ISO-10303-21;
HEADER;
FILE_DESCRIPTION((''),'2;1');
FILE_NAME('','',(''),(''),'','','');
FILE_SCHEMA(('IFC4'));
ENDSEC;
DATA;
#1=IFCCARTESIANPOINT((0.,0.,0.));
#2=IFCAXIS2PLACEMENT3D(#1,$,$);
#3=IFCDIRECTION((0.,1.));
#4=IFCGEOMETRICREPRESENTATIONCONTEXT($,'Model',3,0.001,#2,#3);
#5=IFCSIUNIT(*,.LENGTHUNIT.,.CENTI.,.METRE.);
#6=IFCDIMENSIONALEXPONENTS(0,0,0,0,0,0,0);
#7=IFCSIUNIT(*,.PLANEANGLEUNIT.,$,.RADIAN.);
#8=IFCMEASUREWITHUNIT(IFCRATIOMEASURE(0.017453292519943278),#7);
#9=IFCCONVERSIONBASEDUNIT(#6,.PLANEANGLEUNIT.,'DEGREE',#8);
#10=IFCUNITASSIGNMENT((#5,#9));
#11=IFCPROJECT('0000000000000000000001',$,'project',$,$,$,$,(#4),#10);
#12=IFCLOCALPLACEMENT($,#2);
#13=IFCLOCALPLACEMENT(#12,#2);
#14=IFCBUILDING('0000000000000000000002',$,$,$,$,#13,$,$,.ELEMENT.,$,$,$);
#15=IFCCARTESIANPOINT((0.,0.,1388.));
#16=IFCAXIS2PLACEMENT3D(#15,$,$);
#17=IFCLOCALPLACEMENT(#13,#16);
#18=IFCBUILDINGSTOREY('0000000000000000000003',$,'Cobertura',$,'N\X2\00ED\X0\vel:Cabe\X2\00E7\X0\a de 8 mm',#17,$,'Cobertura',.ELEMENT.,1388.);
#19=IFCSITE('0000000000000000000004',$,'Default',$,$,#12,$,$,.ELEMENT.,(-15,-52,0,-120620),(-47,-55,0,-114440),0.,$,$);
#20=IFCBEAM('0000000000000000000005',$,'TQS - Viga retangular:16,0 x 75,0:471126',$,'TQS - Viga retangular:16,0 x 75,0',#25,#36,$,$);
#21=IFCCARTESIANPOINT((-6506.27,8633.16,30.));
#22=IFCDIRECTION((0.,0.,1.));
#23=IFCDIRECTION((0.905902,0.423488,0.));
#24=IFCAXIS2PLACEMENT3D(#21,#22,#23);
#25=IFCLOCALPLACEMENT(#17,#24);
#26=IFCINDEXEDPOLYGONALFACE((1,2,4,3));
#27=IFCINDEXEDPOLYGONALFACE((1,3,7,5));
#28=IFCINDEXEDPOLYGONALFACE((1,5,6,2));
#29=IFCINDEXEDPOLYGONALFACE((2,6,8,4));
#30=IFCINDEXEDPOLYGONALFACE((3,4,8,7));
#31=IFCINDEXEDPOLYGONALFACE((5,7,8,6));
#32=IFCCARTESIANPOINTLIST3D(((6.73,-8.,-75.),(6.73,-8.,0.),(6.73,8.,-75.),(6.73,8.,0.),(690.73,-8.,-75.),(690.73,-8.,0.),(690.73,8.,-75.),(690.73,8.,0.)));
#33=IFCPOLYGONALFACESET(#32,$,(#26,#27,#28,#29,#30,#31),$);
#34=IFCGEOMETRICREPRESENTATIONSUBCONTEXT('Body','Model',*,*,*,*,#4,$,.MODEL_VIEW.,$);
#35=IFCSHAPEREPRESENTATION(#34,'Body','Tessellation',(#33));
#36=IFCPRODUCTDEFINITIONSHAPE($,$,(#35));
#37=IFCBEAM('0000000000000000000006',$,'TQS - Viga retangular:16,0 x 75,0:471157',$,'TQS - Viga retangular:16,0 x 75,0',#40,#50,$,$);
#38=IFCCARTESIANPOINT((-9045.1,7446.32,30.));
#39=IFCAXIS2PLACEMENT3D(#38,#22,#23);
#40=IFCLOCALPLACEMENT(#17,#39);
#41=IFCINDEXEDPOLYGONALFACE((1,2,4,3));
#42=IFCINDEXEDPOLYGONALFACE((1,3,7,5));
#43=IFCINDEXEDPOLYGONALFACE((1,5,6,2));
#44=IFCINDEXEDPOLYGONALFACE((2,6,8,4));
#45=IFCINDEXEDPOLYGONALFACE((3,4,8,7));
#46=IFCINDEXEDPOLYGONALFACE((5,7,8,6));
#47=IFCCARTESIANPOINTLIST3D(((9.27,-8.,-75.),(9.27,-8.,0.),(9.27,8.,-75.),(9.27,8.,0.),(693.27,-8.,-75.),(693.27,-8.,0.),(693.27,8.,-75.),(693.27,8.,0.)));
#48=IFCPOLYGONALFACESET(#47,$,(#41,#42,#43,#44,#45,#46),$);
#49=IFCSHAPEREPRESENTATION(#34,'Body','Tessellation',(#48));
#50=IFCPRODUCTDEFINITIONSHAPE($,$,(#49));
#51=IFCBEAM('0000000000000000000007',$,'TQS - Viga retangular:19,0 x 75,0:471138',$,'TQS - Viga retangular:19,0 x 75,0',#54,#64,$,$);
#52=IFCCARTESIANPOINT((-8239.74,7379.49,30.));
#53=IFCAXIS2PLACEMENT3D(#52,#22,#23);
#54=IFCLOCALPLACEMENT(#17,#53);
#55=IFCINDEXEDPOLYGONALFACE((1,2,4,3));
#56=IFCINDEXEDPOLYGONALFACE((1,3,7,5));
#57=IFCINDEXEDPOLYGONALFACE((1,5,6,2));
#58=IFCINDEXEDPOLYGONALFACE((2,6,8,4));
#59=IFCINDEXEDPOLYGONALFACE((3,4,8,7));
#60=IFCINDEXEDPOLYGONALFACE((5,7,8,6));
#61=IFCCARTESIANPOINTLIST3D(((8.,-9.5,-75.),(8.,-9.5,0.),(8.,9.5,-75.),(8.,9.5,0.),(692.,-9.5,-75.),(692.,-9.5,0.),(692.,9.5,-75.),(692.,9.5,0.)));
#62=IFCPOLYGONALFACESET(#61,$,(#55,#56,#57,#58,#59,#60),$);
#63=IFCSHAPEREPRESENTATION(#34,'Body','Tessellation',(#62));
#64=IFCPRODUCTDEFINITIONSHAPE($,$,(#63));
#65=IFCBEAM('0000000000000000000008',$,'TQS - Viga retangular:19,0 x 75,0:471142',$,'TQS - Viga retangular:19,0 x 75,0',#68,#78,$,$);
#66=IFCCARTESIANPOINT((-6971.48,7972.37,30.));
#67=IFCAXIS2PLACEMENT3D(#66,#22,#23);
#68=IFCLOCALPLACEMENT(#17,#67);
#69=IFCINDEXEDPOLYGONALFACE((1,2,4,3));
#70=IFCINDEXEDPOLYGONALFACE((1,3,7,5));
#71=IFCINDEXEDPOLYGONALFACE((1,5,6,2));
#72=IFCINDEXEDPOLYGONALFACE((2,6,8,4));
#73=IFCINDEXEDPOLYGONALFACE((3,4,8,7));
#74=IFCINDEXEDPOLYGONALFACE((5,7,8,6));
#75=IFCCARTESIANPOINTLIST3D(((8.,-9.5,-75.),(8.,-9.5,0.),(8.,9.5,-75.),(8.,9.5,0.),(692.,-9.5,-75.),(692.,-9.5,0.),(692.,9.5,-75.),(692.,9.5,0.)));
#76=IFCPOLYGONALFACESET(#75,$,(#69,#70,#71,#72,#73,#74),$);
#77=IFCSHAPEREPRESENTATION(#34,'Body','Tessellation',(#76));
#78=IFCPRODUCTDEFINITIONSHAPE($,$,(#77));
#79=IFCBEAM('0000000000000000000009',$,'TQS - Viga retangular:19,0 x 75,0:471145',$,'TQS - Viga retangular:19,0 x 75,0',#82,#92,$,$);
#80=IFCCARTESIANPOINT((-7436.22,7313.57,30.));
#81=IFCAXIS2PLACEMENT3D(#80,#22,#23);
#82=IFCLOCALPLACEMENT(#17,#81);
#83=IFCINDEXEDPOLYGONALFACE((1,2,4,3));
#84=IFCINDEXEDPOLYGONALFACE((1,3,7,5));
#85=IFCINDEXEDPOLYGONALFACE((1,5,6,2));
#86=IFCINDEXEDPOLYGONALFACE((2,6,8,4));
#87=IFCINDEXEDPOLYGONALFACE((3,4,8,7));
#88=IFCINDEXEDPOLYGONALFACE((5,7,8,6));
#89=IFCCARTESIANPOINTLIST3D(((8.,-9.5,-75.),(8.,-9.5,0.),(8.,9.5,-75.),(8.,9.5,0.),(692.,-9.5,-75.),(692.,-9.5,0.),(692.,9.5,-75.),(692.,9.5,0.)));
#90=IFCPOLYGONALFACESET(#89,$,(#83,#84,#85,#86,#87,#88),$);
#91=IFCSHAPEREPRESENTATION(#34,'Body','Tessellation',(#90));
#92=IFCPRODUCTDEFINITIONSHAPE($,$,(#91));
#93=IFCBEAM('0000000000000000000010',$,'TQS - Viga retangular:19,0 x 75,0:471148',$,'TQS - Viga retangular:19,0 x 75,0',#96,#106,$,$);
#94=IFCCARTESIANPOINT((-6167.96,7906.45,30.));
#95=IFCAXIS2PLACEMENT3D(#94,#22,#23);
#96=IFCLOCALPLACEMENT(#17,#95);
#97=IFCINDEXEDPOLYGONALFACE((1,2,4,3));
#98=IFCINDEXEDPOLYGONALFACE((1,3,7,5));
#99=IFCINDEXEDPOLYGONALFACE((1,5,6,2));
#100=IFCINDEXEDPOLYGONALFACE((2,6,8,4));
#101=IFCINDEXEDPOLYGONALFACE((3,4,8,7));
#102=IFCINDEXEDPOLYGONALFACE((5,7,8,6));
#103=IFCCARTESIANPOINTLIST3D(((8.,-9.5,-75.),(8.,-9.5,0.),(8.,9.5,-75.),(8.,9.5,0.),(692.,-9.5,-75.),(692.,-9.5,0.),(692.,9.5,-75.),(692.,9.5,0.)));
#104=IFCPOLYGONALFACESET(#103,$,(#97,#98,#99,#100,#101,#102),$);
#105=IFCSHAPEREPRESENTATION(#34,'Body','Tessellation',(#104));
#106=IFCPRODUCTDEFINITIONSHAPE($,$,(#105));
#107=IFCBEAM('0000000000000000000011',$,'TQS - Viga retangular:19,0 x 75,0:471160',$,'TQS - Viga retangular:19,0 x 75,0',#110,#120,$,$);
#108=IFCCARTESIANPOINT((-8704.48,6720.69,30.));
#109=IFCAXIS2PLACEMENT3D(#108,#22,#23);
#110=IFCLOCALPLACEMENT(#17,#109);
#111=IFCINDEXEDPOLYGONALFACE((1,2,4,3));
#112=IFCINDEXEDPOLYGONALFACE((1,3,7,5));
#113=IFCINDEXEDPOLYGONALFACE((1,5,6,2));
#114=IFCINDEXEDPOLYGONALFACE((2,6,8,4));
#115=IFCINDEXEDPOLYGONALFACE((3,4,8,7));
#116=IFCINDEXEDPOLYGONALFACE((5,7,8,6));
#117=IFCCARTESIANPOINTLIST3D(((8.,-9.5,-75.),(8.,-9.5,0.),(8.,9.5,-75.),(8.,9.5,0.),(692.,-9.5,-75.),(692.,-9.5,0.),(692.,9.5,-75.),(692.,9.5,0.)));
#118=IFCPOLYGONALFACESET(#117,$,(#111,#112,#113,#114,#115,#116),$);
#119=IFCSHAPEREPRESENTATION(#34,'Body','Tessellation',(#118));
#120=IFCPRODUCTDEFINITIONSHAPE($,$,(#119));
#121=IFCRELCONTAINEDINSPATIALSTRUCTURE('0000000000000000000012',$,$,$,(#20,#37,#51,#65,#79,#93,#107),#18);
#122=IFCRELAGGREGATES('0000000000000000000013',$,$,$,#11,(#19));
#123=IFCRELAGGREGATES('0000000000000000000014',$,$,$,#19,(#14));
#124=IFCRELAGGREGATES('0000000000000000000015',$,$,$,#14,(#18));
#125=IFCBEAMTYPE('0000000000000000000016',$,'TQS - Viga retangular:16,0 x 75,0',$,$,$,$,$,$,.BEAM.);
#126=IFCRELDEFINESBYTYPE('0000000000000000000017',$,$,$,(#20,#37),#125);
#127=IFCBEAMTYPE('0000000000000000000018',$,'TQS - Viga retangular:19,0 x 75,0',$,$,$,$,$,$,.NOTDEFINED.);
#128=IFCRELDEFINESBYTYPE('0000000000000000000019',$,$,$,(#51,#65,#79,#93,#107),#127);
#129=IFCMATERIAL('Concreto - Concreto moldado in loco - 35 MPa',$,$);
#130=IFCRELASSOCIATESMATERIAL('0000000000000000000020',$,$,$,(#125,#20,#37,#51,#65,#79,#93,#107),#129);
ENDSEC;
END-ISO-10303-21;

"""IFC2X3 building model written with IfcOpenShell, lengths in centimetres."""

from ifc_helpers import new_model, entity, si_unit, converted_unit, direction, frame, frame_2d, origin, place, context, subcontext, project, spatial, rectangle, extrude, material, type_object, element, save


model = new_model("IFC2X3")

# Units and contexts
model_context = context("Model", 3, precision=0.001, world=origin(), true_north=direction((0.0, 1.0)))
body_context = subcontext(model_context, "Body", "Model", "MODEL_VIEW")
ifc_project = project(units=[si_unit("LENGTHUNIT", "METRE", prefix="CENTI"), converted_unit("PLANEANGLEUNIT", "DEGREE", entity("IfcRatioMeasure", 0.017453292519943278), si_unit("PLANEANGLEUNIT", "RADIAN"), dimensions=[0, 0, 0, 0, 0, 0, 0])], contexts=[model_context])

# Site, building, storey
site_placement = place(None, origin())
site = spatial("IfcSite", under=ifc_project, at=site_placement, Name="Default", CompositionType="ELEMENT", RefLatitude=(-15, -52, 0, -120620), RefLongitude=(-47, -55, 0, -114440), RefElevation=0.0)
building_placement = place(site_placement, origin())
building = spatial("IfcBuilding", under=site, at=building_placement, CompositionType="ELEMENT")
storey_placement = place(building_placement, frame((0.0, 0.0, 1388.0)))
storey = spatial("IfcBuildingStorey", under=building, at=storey_placement, Name="Cobertura", ObjectType="Nível:Cabeça de 8 mm", LongName="Cobertura", CompositionType="ELEMENT", Elevation=1388.0)

# Beams
ifc_material = material(Name="Concreto - Concreto moldado in loco - 35 MPa")
beam_type_1 = type_object("IfcBeamType", Name="TQS - Viga retangular:16,0 x 75,0", PredefinedType="BEAM", material=ifc_material)
beam_1_placement = place(storey_placement, frame((-6506.27, 8633.16, 30.0), z_axis=(0.0, 0.0, 1.0), x_axis=(0.905902, 0.423488, 0.0)))
element("IfcBeam", 1, at=beam_1_placement, inside=storey, type_object=beam_type_1, material=ifc_material, Name="TQS - Viga retangular:16,0 x 75,0:471126", ObjectType="TQS - Viga retangular:16,0 x 75,0", context=body_context, shape_type="SweptSolid", body=[
    extrude(rectangle(XDim=75.0, YDim=16.0, at=frame_2d((0.0, 0.0), x_axis=(1.0, 0.0))), frame((6.73, 0.0, -37.5), z_axis=(1.0, 0.0, 0.0), x_axis=(0.0, 0.0, -1.0)), (0.0, 0.0, 1.0), 684.0),
])
beam_2_placement = place(storey_placement, frame((-9045.1, 7446.32, 30.0), z_axis=(0.0, 0.0, 1.0), x_axis=(0.905902, 0.423488, 0.0)))
element("IfcBeam", 2, at=beam_2_placement, inside=storey, type_object=beam_type_1, material=ifc_material, Name="TQS - Viga retangular:16,0 x 75,0:471157", ObjectType="TQS - Viga retangular:16,0 x 75,0", context=body_context, shape_type="SweptSolid", body=[
    extrude(rectangle(XDim=75.0, YDim=16.0, at=frame_2d((0.0, 0.0), x_axis=(1.0, 0.0))), frame((9.27, 0.0, -37.5), z_axis=(1.0, 0.0, 0.0), x_axis=(0.0, 0.0, -1.0)), (0.0, 0.0, 1.0), 684.0),
])
beam_type_2 = type_object("IfcBeamType", Name="TQS - Viga retangular:19,0 x 75,0", PredefinedType="NOTDEFINED")
beam_3_placement = place(storey_placement, frame((-8239.74, 7379.49, 30.0), z_axis=(0.0, 0.0, 1.0), x_axis=(0.905902, 0.423488, 0.0)))
element("IfcBeam", 3, at=beam_3_placement, inside=storey, type_object=beam_type_2, material=ifc_material, Name="TQS - Viga retangular:19,0 x 75,0:471138", ObjectType="TQS - Viga retangular:19,0 x 75,0", context=body_context, shape_type="SweptSolid", body=[
    extrude(rectangle(XDim=75.0, YDim=19.0, at=frame_2d((0.0, 0.0), x_axis=(1.0, 0.0))), frame((8.0, 0.0, -37.5), z_axis=(1.0, 0.0, 0.0), x_axis=(0.0, 0.0, -1.0)), (0.0, 0.0, 1.0), 684.0),
])
beam_4_placement = place(storey_placement, frame((-6971.48, 7972.37, 30.0), z_axis=(0.0, 0.0, 1.0), x_axis=(0.905902, 0.423488, 0.0)))
element("IfcBeam", 4, at=beam_4_placement, inside=storey, type_object=beam_type_2, material=ifc_material, Name="TQS - Viga retangular:19,0 x 75,0:471142", ObjectType="TQS - Viga retangular:19,0 x 75,0", context=body_context, shape_type="SweptSolid", body=[
    extrude(rectangle(XDim=75.0, YDim=19.0, at=frame_2d((0.0, 0.0), x_axis=(1.0, 0.0))), frame((8.0, 0.0, -37.5), z_axis=(1.0, 0.0, 0.0), x_axis=(0.0, 0.0, -1.0)), (0.0, 0.0, 1.0), 684.0),
])
beam_5_placement = place(storey_placement, frame((-7436.22, 7313.57, 30.0), z_axis=(0.0, 0.0, 1.0), x_axis=(0.905902, 0.423488, 0.0)))
element("IfcBeam", 5, at=beam_5_placement, inside=storey, type_object=beam_type_2, material=ifc_material, Name="TQS - Viga retangular:19,0 x 75,0:471145", ObjectType="TQS - Viga retangular:19,0 x 75,0", context=body_context, shape_type="SweptSolid", body=[
    extrude(rectangle(XDim=75.0, YDim=19.0, at=frame_2d((0.0, 0.0), x_axis=(1.0, 0.0))), frame((8.0, 0.0, -37.5), z_axis=(1.0, 0.0, 0.0), x_axis=(0.0, 0.0, -1.0)), (0.0, 0.0, 1.0), 684.0),
])
beam_6_placement = place(storey_placement, frame((-6167.96, 7906.45, 30.0), z_axis=(0.0, 0.0, 1.0), x_axis=(0.905902, 0.423488, 0.0)))
element("IfcBeam", 6, at=beam_6_placement, inside=storey, type_object=beam_type_2, material=ifc_material, Name="TQS - Viga retangular:19,0 x 75,0:471148", ObjectType="TQS - Viga retangular:19,0 x 75,0", context=body_context, shape_type="SweptSolid", body=[
    extrude(rectangle(XDim=75.0, YDim=19.0, at=frame_2d((0.0, 0.0), x_axis=(1.0, 0.0))), frame((8.0, 0.0, -37.5), z_axis=(1.0, 0.0, 0.0), x_axis=(0.0, 0.0, -1.0)), (0.0, 0.0, 1.0), 684.0),
])
beam_7_placement = place(storey_placement, frame((-8704.48, 6720.69, 30.0), z_axis=(0.0, 0.0, 1.0), x_axis=(0.905902, 0.423488, 0.0)))
element("IfcBeam", 7, at=beam_7_placement, inside=storey, type_object=beam_type_2, material=ifc_material, Name="TQS - Viga retangular:19,0 x 75,0:471160", ObjectType="TQS - Viga retangular:19,0 x 75,0", context=body_context, shape_type="SweptSolid", body=[
    extrude(rectangle(XDim=75.0, YDim=19.0, at=frame_2d((0.0, 0.0), x_axis=(1.0, 0.0))), frame((8.0, 0.0, -37.5), z_axis=(1.0, 0.0, 0.0), x_axis=(0.0, 0.0, -1.0)), (0.0, 0.0, 1.0), 684.0),
])

save(model, "model.ifc")
